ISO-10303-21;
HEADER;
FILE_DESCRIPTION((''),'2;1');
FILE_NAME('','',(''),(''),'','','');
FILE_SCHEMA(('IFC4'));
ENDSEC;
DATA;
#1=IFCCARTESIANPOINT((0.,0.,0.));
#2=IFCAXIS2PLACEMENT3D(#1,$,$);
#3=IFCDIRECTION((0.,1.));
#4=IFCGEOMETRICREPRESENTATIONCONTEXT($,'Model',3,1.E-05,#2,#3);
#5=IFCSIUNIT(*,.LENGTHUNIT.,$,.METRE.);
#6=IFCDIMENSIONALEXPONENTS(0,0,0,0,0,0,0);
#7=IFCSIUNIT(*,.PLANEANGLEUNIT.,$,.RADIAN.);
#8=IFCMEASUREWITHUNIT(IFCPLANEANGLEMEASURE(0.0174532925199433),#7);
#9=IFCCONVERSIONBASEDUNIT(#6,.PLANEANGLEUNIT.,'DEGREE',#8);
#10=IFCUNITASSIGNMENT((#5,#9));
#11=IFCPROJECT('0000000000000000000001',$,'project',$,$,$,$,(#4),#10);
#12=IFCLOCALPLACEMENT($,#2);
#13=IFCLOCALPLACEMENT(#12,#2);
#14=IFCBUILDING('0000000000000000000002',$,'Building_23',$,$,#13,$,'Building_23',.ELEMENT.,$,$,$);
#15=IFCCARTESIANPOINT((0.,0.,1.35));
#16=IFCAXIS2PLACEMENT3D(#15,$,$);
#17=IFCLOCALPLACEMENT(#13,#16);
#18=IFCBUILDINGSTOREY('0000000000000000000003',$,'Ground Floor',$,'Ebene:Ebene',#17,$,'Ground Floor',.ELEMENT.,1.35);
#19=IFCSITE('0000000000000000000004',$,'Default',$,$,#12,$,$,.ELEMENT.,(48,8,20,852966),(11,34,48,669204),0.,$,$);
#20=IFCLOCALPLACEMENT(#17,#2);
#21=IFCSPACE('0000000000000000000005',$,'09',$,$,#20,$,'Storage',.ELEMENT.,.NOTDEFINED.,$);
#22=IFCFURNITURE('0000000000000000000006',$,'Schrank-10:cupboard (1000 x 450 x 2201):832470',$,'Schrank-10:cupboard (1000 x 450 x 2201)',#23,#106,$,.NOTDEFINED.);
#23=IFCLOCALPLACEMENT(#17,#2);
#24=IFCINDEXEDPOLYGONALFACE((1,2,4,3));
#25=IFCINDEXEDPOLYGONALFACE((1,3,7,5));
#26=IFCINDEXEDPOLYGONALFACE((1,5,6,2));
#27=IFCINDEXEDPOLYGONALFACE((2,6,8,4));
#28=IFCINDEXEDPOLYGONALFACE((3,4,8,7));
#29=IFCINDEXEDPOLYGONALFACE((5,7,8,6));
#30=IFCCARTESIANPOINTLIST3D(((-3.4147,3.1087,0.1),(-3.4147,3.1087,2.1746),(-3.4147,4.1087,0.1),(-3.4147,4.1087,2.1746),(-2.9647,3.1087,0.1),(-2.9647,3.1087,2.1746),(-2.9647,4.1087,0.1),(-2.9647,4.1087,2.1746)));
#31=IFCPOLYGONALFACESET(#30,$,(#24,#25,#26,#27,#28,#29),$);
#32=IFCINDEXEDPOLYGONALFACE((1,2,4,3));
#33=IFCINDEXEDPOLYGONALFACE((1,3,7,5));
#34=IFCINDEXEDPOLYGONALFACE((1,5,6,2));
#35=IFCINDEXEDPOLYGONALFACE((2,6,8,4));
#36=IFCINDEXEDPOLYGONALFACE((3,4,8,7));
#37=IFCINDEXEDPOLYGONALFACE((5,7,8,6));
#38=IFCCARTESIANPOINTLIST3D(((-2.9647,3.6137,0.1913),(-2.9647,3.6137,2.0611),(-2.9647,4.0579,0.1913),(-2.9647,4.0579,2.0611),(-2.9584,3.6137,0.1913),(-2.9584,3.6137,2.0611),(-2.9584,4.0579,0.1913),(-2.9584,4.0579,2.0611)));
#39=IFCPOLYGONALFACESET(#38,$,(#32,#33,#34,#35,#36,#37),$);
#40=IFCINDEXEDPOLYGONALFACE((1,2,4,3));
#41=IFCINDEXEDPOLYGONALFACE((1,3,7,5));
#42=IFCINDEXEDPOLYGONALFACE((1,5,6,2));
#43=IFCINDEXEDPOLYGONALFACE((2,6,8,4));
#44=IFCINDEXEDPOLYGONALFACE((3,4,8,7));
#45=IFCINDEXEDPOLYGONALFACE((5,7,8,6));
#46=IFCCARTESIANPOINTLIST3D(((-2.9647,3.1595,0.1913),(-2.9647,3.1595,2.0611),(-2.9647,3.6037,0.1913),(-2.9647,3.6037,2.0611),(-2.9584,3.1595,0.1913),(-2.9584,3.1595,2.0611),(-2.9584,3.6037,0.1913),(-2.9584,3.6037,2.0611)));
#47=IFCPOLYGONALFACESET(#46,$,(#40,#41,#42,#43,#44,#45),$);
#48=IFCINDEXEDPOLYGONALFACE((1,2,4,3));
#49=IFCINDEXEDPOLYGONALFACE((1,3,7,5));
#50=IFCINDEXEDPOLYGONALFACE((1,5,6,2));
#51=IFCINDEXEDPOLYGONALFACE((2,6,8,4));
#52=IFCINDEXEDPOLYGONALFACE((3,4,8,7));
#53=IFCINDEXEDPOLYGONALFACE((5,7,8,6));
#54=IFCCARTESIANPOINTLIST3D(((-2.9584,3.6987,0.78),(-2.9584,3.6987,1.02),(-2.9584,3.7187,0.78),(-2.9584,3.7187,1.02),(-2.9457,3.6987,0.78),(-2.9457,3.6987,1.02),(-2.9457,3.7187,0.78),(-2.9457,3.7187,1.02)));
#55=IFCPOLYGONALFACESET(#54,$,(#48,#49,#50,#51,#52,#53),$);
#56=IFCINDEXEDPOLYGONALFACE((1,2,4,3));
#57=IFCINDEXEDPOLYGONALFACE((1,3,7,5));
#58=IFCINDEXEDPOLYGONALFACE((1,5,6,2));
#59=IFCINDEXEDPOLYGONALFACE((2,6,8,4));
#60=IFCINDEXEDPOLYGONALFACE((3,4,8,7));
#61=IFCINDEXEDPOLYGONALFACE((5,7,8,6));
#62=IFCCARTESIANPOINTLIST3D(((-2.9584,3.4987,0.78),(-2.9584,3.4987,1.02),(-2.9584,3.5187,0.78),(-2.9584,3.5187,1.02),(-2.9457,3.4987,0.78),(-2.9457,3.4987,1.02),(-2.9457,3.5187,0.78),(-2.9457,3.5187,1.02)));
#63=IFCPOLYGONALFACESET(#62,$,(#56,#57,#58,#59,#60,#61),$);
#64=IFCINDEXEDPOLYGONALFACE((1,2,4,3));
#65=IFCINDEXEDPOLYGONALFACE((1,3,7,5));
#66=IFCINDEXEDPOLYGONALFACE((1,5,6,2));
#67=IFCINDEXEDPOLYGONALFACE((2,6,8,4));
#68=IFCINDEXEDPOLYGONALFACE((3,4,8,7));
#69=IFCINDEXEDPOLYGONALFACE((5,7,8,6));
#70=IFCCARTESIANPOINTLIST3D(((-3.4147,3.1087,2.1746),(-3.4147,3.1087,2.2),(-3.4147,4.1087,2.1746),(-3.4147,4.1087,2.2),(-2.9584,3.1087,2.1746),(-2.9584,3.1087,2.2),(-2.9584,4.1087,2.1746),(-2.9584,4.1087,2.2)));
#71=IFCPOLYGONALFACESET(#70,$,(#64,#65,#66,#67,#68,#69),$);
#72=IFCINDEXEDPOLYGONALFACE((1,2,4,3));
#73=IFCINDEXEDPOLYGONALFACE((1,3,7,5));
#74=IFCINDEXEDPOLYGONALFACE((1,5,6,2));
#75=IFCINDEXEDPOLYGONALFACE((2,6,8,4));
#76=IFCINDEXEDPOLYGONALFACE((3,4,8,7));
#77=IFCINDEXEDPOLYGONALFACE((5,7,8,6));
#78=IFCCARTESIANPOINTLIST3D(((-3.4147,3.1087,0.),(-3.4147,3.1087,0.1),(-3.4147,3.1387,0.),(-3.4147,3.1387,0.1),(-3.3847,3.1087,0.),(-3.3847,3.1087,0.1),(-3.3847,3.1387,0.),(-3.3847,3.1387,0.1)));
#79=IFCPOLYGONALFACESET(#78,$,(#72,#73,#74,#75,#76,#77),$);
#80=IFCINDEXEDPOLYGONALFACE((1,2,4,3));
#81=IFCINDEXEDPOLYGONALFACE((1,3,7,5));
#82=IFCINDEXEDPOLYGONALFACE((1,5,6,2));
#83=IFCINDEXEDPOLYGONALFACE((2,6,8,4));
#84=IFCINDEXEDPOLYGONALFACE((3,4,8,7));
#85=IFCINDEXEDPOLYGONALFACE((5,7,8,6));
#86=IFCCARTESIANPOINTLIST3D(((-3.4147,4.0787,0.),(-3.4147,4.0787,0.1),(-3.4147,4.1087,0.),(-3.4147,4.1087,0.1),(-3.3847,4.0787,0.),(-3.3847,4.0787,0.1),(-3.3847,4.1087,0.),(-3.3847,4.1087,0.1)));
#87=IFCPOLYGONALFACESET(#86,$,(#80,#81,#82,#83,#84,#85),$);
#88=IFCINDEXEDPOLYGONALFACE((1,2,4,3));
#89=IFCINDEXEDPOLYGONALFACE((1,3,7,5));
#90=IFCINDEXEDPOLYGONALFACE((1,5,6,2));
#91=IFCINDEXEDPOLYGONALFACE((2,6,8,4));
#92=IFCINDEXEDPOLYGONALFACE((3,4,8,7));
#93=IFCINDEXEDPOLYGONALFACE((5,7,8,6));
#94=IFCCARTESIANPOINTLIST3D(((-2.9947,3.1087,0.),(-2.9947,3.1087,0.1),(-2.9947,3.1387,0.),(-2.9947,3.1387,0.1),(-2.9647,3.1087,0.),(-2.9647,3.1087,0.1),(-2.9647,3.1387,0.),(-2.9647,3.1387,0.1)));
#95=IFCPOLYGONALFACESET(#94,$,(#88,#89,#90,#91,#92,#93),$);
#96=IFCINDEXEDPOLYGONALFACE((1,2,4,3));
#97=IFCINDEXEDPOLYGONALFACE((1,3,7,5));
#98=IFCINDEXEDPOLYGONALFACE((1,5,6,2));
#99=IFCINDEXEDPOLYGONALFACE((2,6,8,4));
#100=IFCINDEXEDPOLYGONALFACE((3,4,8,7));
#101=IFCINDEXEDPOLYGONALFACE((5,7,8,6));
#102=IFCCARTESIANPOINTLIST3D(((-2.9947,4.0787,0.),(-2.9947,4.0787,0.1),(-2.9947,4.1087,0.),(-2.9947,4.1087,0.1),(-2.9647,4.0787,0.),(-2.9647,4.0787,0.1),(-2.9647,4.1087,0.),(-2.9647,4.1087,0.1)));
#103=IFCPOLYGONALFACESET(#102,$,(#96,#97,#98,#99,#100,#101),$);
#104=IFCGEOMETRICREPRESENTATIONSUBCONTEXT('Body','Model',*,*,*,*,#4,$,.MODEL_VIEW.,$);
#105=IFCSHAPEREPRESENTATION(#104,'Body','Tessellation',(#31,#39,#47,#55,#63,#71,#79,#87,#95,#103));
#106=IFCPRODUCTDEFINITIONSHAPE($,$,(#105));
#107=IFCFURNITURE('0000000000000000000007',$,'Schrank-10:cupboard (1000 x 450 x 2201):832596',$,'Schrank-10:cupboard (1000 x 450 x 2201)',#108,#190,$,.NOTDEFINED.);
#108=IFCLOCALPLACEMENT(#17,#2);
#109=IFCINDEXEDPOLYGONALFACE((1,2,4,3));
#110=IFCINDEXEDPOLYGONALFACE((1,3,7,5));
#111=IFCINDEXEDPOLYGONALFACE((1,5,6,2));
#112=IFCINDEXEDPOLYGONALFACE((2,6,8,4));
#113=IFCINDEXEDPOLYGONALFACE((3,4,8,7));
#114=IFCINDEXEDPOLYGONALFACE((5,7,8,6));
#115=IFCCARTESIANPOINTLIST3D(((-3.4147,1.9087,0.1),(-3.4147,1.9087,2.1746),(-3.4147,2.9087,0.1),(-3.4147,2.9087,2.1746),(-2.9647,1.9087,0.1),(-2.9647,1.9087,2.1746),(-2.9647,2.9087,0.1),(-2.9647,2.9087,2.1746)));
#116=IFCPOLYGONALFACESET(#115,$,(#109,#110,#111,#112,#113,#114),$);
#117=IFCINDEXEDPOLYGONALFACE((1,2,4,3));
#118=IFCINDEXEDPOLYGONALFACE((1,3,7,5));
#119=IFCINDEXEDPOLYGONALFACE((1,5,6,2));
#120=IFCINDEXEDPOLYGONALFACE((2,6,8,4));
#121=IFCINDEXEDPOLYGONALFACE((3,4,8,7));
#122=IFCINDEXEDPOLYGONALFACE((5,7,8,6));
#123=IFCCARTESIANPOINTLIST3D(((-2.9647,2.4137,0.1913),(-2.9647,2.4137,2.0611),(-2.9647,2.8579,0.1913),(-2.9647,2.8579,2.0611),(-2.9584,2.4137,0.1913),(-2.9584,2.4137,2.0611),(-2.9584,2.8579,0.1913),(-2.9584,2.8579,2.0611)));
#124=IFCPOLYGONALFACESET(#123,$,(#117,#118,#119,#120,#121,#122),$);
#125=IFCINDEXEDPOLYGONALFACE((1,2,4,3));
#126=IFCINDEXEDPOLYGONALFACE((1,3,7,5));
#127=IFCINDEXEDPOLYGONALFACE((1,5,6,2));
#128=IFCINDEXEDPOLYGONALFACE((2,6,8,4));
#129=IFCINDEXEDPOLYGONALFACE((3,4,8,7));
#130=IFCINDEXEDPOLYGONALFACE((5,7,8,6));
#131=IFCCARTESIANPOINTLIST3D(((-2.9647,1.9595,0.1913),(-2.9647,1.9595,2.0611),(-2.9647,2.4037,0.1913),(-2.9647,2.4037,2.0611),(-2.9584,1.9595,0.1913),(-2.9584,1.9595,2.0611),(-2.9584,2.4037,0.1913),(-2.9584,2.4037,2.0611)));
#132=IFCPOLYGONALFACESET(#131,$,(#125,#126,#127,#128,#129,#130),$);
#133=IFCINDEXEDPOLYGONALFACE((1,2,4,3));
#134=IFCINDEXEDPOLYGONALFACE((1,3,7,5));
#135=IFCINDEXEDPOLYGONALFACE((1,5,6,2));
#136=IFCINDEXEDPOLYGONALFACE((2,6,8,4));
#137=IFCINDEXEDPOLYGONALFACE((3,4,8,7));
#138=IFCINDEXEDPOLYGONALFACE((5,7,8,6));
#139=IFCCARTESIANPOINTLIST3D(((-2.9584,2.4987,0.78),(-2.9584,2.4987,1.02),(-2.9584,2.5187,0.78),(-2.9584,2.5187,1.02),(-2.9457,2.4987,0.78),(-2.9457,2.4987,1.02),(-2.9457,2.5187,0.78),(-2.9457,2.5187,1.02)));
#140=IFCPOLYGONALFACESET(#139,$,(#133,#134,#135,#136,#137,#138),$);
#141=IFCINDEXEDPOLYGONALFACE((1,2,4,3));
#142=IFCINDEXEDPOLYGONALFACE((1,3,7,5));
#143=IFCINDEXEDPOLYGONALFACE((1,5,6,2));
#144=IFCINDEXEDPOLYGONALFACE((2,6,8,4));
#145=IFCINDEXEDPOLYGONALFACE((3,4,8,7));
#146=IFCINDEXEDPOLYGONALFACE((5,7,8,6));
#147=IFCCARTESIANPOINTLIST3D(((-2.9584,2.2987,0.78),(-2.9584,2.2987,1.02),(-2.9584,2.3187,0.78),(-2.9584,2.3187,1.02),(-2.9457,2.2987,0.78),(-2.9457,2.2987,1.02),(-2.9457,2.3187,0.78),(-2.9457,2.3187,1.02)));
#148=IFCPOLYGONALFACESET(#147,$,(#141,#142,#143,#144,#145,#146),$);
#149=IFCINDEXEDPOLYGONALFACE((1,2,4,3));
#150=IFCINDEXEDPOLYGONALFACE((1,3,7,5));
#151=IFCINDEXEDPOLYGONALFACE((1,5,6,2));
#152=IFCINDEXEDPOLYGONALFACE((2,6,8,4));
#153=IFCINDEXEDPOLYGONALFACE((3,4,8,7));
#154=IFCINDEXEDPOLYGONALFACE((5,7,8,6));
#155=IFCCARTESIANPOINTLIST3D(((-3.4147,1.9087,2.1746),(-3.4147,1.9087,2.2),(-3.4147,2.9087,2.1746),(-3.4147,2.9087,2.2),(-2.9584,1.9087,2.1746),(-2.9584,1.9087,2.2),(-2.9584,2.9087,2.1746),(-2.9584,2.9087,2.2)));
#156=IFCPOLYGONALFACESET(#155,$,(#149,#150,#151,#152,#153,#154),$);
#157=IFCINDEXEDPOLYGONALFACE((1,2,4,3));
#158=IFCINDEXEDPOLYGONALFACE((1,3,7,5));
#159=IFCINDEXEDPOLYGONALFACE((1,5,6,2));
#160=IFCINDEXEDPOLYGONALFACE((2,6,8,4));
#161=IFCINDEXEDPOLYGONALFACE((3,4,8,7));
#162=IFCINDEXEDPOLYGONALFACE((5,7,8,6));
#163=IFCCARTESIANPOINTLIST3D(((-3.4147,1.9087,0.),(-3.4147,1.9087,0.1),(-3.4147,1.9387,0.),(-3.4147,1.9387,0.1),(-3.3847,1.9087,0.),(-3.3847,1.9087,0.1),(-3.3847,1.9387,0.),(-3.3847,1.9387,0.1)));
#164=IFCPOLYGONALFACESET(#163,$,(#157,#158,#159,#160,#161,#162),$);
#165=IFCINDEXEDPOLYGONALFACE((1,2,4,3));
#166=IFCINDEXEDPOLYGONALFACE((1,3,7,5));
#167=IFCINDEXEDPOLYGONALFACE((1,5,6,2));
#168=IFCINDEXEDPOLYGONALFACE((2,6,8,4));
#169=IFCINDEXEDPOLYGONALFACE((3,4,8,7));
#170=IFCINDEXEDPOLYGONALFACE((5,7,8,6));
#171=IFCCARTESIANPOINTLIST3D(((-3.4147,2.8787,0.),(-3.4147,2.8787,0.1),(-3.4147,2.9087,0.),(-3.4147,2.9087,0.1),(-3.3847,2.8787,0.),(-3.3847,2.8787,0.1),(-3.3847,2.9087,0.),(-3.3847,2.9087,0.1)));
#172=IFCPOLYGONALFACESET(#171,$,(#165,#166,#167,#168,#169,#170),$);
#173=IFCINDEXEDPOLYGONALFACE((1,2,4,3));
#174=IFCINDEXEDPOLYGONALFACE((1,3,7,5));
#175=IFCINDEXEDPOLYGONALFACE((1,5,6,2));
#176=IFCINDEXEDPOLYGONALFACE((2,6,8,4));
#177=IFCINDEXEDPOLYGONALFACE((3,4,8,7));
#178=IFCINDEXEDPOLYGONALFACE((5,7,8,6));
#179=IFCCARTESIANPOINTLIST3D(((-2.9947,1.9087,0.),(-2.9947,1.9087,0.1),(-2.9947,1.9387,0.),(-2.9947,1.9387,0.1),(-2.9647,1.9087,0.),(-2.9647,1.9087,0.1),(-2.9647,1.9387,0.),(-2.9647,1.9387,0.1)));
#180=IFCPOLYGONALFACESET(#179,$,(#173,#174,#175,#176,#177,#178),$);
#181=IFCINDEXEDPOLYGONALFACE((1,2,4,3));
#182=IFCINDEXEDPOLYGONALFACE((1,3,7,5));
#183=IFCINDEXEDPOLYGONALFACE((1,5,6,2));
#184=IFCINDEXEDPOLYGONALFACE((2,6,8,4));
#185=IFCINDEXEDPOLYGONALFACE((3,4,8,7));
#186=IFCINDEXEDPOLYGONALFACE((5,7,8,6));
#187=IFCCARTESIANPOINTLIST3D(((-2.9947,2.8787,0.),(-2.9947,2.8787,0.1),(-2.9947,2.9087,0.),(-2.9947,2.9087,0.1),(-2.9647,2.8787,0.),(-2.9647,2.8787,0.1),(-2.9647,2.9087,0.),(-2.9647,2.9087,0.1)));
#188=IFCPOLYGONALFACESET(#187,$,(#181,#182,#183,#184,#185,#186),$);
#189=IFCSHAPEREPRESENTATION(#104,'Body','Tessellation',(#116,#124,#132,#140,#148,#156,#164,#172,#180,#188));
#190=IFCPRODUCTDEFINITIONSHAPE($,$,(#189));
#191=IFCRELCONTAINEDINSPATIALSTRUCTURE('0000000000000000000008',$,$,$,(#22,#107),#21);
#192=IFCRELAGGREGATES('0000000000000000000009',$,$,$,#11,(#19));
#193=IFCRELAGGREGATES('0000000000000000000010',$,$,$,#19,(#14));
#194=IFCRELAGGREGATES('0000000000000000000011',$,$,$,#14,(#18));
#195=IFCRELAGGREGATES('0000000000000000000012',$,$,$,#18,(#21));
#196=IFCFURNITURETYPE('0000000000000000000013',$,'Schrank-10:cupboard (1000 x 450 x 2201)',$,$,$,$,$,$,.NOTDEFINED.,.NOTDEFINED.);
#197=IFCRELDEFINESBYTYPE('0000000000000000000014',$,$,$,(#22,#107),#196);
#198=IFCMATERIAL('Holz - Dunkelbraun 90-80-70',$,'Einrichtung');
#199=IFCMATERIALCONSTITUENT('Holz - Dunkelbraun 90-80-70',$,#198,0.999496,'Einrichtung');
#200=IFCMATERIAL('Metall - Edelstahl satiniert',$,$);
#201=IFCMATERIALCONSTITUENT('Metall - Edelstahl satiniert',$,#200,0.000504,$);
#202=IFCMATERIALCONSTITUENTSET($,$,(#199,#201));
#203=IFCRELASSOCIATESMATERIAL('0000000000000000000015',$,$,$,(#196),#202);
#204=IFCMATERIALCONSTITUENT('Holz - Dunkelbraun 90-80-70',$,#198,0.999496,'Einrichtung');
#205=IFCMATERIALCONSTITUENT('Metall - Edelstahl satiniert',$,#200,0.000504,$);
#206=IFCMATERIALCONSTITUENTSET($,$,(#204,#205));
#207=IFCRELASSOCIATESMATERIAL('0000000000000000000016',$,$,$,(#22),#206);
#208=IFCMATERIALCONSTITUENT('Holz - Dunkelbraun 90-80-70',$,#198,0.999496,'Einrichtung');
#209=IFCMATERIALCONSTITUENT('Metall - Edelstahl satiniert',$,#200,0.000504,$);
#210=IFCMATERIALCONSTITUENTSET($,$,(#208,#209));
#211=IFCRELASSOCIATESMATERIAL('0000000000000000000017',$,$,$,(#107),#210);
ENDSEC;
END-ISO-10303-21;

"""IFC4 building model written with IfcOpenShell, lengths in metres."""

from ifc_helpers import new_model, entity, si_unit, converted_unit, direction, frame, origin, place, context, subcontext, project, spatial, indexed_curve, outline, extrude, source, transform, mapped, material, constituent, constituent_set, type_object, type_shapes, element, save


model = new_model("IFC4")

# Units and contexts
model_context = context("Model", 3, precision=1e-05, world=origin(), true_north=direction((0.0, 1.0)))
body_context = subcontext(model_context, "Body", "Model", "MODEL_VIEW")
ifc_project = project(units=[si_unit("LENGTHUNIT", "METRE"), converted_unit("PLANEANGLEUNIT", "DEGREE", entity("IfcPlaneAngleMeasure", 0.0174532925199433), si_unit("PLANEANGLEUNIT", "RADIAN"), dimensions=[0, 0, 0, 0, 0, 0, 0])], contexts=[model_context])

# Site, building, storey
site_placement = place(None, origin())
site = spatial("IfcSite", under=ifc_project, at=site_placement, Name="Default", CompositionType="ELEMENT", RefLatitude=(48, 8, 20, 852966), RefLongitude=(11, 34, 48, 669204), RefElevation=0.0)
building_placement = place(site_placement, origin())
building = spatial("IfcBuilding", under=site, at=building_placement, Name="Building_23", LongName="Building_23", CompositionType="ELEMENT")
storey_placement = place(building_placement, frame((0.0, 0.0, 1.35)))
storey = spatial("IfcBuildingStorey", under=building, at=storey_placement, Name="Ground Floor", ObjectType="Ebene:Ebene", LongName="Ground Floor", CompositionType="ELEMENT", Elevation=1.35)

# Shared definitions
ifc_material_1 = material(Name="Holz - Dunkelbraun 90-80-70", Category="Einrichtung")
ifc_material_2 = material(Name="Metall - Edelstahl satiniert")
ifc_constituent_1 = constituent(ifc_material_1, Name="Holz - Dunkelbraun 90-80-70", Category="Einrichtung", fraction=0.999496)
ifc_constituent_2 = constituent(ifc_material_2, Name="Metall - Edelstahl satiniert", fraction=0.000504)
ifc_constituent_set_1 = constituent_set(constituents=[ifc_constituent_1, ifc_constituent_2])
furniture_type = type_object("IfcFurnitureType", Name="Schrank-10:cupboard (1000 x 450 x 2201)", AssemblyPlace="NOTDEFINED", PredefinedType="NOTDEFINED", material=ifc_constituent_set_1)
shared_shape_1 = source(origin(), body_context, "Body", "SweptSolid", [
    extrude(outline(indexed_curve([(-0.225, -0.5), (0.225, -0.5), (0.225, 0.5), (-0.225, 0.5), (-0.225, -0.5)], self_intersect=False)), frame((-0.2692, -0.3632, 0.1), z_axis=(0.0, 0.0, 1.0), x_axis=(0.0, 1.0, 0.0)), (0.0, 0.0, 1.0), 2.0746),
    extrude(outline(indexed_curve([(-0.0032, -0.2221), (0.0032, -0.2221), (0.0032, 0.2221), (-0.0032, 0.2221), (-0.0032, -0.2221)], self_intersect=False)), frame((-0.0421, -0.5913, 0.1913), z_axis=(0.0, 0.0, 1.0), x_axis=(0.0, 1.0, 0.0)), (0.0, 0.0, 1.0), 1.8698),
    extrude(outline(indexed_curve([(-0.0032, -0.2221), (0.0032, -0.2221), (0.0032, 0.2221), (-0.0032, 0.2221), (-0.0032, -0.2221)], self_intersect=False)), frame((-0.4963, -0.5913, 0.1913), z_axis=(0.0, 0.0, 1.0), x_axis=(0.0, 1.0, 0.0)), (0.0, 0.0, 1.0), 1.8698),
    extrude(outline(indexed_curve([(-0.0063, -0.01), (0.0063, -0.01), (0.0063, 0.01), (-0.0063, 0.01), (-0.0063, -0.01)], self_intersect=False)), frame((-0.1692, -0.6009, 0.78), z_axis=(0.0, 0.0, 1.0), x_axis=(0.0, 1.0, 0.0)), (0.0, 0.0, 1.0), 0.24),
    extrude(outline(indexed_curve([(-0.0063, -0.01), (0.0063, -0.01), (0.0063, 0.01), (-0.0063, 0.01), (-0.0063, -0.01)], self_intersect=False)), frame((-0.3692, -0.6009, 0.78), z_axis=(0.0, 0.0, 1.0), x_axis=(0.0, 1.0, 0.0)), (0.0, 0.0, 1.0), 0.24),
    extrude(outline(indexed_curve([(-0.5, -0.2282), (0.5, -0.2282), (0.5, 0.2282), (-0.5, 0.2282), (-0.5, -0.2282)], self_intersect=False)), frame((-0.2692, -0.3663, 2.1746), z_axis=(0.0, 0.0, 1.0), x_axis=(-1.0, 0.0, 0.0)), (0.0, 0.0, 1.0), 0.0254),
    extrude(outline(indexed_curve([(-0.015, -0.015), (0.015, -0.015), (0.015, 0.015), (-0.015, 0.015), (-0.015, -0.015)], self_intersect=False)), frame((-0.7542, -0.1532, 0.0), z_axis=(0.0, 0.0, 1.0), x_axis=(-1.0, 0.0, 0.0)), (0.0, 0.0, 1.0), 0.1),
    extrude(outline(indexed_curve([(-0.015, -0.015), (0.015, -0.015), (0.015, 0.015), (-0.015, 0.015), (-0.015, -0.015)], self_intersect=False)), frame((0.2158, -0.1532, 0.0), z_axis=(0.0, 0.0, 1.0), x_axis=(0.0, -1.0, 0.0)), (0.0, 0.0, 1.0), 0.1),
    extrude(outline(indexed_curve([(-0.015, -0.015), (0.015, -0.015), (0.015, 0.015), (-0.015, 0.015), (-0.015, -0.015)], self_intersect=False)), frame((-0.7542, -0.5732, 0.0), z_axis=(0.0, 0.0, 1.0), x_axis=(0.0, 1.0, 0.0)), (0.0, 0.0, 1.0), 0.1),
    extrude(outline(indexed_curve([(-0.015, -0.015), (0.015, -0.015), (0.015, 0.015), (-0.015, 0.015), (-0.015, -0.015)], self_intersect=False)), frame((0.2158, -0.5732, 0.0)), (0.0, 0.0, 1.0), 0.1),
])
type_shapes(furniture_type, [shared_shape_1])

# Shared definitions
space_1_placement = place(storey_placement, origin())
space_1 = spatial("IfcSpace", under=storey, at=space_1_placement, Name="09", LongName="Storage", CompositionType="ELEMENT", PredefinedType="NOTDEFINED")

# Furniture
ifc_constituent_3 = constituent(ifc_material_1, Name="Holz - Dunkelbraun 90-80-70", Category="Einrichtung", fraction=0.999496)
ifc_constituent_4 = constituent(ifc_material_2, Name="Metall - Edelstahl satiniert", fraction=0.000504)
ifc_constituent_set_2 = constituent_set(constituents=[ifc_constituent_3, ifc_constituent_4])
furniture_1_placement = place(space_1_placement, frame((-3.5529, 3.8779, 0.0), z_axis=(0.0, 0.0, 1.0), x_axis=(0.0, 1.0, 0.0)))
element("IfcFurniture", 1, at=furniture_1_placement, inside=space_1, type_object=furniture_type, material=ifc_constituent_set_2, Name="Schrank-10:cupboard (1000 x 450 x 2201):832470", ObjectType="Schrank-10:cupboard (1000 x 450 x 2201)", PredefinedType="NOTDEFINED", context=body_context, shape_type="MappedRepresentation", body=[
    mapped(shared_shape_1, transform((0.0, 0.0, 0.0), scale=1.0)),
])
ifc_constituent_5 = constituent(ifc_material_1, Name="Holz - Dunkelbraun 90-80-70", Category="Einrichtung", fraction=0.999496)
ifc_constituent_6 = constituent(ifc_material_2, Name="Metall - Edelstahl satiniert", fraction=0.000504)
ifc_constituent_set_3 = constituent_set(constituents=[ifc_constituent_5, ifc_constituent_6])
furniture_2_placement = place(space_1_placement, frame((-3.5529, 2.6779, 0.0), z_axis=(0.0, 0.0, 1.0), x_axis=(0.0, 1.0, 0.0)))
element("IfcFurniture", 2, at=furniture_2_placement, inside=space_1, type_object=furniture_type, material=ifc_constituent_set_3, Name="Schrank-10:cupboard (1000 x 450 x 2201):832596", ObjectType="Schrank-10:cupboard (1000 x 450 x 2201)", PredefinedType="NOTDEFINED", context=body_context, shape_type="MappedRepresentation", body=[
    mapped(shared_shape_1, transform((0.0, 0.0, 0.0), scale=1.0)),
])

save(model, "model.ifc")
